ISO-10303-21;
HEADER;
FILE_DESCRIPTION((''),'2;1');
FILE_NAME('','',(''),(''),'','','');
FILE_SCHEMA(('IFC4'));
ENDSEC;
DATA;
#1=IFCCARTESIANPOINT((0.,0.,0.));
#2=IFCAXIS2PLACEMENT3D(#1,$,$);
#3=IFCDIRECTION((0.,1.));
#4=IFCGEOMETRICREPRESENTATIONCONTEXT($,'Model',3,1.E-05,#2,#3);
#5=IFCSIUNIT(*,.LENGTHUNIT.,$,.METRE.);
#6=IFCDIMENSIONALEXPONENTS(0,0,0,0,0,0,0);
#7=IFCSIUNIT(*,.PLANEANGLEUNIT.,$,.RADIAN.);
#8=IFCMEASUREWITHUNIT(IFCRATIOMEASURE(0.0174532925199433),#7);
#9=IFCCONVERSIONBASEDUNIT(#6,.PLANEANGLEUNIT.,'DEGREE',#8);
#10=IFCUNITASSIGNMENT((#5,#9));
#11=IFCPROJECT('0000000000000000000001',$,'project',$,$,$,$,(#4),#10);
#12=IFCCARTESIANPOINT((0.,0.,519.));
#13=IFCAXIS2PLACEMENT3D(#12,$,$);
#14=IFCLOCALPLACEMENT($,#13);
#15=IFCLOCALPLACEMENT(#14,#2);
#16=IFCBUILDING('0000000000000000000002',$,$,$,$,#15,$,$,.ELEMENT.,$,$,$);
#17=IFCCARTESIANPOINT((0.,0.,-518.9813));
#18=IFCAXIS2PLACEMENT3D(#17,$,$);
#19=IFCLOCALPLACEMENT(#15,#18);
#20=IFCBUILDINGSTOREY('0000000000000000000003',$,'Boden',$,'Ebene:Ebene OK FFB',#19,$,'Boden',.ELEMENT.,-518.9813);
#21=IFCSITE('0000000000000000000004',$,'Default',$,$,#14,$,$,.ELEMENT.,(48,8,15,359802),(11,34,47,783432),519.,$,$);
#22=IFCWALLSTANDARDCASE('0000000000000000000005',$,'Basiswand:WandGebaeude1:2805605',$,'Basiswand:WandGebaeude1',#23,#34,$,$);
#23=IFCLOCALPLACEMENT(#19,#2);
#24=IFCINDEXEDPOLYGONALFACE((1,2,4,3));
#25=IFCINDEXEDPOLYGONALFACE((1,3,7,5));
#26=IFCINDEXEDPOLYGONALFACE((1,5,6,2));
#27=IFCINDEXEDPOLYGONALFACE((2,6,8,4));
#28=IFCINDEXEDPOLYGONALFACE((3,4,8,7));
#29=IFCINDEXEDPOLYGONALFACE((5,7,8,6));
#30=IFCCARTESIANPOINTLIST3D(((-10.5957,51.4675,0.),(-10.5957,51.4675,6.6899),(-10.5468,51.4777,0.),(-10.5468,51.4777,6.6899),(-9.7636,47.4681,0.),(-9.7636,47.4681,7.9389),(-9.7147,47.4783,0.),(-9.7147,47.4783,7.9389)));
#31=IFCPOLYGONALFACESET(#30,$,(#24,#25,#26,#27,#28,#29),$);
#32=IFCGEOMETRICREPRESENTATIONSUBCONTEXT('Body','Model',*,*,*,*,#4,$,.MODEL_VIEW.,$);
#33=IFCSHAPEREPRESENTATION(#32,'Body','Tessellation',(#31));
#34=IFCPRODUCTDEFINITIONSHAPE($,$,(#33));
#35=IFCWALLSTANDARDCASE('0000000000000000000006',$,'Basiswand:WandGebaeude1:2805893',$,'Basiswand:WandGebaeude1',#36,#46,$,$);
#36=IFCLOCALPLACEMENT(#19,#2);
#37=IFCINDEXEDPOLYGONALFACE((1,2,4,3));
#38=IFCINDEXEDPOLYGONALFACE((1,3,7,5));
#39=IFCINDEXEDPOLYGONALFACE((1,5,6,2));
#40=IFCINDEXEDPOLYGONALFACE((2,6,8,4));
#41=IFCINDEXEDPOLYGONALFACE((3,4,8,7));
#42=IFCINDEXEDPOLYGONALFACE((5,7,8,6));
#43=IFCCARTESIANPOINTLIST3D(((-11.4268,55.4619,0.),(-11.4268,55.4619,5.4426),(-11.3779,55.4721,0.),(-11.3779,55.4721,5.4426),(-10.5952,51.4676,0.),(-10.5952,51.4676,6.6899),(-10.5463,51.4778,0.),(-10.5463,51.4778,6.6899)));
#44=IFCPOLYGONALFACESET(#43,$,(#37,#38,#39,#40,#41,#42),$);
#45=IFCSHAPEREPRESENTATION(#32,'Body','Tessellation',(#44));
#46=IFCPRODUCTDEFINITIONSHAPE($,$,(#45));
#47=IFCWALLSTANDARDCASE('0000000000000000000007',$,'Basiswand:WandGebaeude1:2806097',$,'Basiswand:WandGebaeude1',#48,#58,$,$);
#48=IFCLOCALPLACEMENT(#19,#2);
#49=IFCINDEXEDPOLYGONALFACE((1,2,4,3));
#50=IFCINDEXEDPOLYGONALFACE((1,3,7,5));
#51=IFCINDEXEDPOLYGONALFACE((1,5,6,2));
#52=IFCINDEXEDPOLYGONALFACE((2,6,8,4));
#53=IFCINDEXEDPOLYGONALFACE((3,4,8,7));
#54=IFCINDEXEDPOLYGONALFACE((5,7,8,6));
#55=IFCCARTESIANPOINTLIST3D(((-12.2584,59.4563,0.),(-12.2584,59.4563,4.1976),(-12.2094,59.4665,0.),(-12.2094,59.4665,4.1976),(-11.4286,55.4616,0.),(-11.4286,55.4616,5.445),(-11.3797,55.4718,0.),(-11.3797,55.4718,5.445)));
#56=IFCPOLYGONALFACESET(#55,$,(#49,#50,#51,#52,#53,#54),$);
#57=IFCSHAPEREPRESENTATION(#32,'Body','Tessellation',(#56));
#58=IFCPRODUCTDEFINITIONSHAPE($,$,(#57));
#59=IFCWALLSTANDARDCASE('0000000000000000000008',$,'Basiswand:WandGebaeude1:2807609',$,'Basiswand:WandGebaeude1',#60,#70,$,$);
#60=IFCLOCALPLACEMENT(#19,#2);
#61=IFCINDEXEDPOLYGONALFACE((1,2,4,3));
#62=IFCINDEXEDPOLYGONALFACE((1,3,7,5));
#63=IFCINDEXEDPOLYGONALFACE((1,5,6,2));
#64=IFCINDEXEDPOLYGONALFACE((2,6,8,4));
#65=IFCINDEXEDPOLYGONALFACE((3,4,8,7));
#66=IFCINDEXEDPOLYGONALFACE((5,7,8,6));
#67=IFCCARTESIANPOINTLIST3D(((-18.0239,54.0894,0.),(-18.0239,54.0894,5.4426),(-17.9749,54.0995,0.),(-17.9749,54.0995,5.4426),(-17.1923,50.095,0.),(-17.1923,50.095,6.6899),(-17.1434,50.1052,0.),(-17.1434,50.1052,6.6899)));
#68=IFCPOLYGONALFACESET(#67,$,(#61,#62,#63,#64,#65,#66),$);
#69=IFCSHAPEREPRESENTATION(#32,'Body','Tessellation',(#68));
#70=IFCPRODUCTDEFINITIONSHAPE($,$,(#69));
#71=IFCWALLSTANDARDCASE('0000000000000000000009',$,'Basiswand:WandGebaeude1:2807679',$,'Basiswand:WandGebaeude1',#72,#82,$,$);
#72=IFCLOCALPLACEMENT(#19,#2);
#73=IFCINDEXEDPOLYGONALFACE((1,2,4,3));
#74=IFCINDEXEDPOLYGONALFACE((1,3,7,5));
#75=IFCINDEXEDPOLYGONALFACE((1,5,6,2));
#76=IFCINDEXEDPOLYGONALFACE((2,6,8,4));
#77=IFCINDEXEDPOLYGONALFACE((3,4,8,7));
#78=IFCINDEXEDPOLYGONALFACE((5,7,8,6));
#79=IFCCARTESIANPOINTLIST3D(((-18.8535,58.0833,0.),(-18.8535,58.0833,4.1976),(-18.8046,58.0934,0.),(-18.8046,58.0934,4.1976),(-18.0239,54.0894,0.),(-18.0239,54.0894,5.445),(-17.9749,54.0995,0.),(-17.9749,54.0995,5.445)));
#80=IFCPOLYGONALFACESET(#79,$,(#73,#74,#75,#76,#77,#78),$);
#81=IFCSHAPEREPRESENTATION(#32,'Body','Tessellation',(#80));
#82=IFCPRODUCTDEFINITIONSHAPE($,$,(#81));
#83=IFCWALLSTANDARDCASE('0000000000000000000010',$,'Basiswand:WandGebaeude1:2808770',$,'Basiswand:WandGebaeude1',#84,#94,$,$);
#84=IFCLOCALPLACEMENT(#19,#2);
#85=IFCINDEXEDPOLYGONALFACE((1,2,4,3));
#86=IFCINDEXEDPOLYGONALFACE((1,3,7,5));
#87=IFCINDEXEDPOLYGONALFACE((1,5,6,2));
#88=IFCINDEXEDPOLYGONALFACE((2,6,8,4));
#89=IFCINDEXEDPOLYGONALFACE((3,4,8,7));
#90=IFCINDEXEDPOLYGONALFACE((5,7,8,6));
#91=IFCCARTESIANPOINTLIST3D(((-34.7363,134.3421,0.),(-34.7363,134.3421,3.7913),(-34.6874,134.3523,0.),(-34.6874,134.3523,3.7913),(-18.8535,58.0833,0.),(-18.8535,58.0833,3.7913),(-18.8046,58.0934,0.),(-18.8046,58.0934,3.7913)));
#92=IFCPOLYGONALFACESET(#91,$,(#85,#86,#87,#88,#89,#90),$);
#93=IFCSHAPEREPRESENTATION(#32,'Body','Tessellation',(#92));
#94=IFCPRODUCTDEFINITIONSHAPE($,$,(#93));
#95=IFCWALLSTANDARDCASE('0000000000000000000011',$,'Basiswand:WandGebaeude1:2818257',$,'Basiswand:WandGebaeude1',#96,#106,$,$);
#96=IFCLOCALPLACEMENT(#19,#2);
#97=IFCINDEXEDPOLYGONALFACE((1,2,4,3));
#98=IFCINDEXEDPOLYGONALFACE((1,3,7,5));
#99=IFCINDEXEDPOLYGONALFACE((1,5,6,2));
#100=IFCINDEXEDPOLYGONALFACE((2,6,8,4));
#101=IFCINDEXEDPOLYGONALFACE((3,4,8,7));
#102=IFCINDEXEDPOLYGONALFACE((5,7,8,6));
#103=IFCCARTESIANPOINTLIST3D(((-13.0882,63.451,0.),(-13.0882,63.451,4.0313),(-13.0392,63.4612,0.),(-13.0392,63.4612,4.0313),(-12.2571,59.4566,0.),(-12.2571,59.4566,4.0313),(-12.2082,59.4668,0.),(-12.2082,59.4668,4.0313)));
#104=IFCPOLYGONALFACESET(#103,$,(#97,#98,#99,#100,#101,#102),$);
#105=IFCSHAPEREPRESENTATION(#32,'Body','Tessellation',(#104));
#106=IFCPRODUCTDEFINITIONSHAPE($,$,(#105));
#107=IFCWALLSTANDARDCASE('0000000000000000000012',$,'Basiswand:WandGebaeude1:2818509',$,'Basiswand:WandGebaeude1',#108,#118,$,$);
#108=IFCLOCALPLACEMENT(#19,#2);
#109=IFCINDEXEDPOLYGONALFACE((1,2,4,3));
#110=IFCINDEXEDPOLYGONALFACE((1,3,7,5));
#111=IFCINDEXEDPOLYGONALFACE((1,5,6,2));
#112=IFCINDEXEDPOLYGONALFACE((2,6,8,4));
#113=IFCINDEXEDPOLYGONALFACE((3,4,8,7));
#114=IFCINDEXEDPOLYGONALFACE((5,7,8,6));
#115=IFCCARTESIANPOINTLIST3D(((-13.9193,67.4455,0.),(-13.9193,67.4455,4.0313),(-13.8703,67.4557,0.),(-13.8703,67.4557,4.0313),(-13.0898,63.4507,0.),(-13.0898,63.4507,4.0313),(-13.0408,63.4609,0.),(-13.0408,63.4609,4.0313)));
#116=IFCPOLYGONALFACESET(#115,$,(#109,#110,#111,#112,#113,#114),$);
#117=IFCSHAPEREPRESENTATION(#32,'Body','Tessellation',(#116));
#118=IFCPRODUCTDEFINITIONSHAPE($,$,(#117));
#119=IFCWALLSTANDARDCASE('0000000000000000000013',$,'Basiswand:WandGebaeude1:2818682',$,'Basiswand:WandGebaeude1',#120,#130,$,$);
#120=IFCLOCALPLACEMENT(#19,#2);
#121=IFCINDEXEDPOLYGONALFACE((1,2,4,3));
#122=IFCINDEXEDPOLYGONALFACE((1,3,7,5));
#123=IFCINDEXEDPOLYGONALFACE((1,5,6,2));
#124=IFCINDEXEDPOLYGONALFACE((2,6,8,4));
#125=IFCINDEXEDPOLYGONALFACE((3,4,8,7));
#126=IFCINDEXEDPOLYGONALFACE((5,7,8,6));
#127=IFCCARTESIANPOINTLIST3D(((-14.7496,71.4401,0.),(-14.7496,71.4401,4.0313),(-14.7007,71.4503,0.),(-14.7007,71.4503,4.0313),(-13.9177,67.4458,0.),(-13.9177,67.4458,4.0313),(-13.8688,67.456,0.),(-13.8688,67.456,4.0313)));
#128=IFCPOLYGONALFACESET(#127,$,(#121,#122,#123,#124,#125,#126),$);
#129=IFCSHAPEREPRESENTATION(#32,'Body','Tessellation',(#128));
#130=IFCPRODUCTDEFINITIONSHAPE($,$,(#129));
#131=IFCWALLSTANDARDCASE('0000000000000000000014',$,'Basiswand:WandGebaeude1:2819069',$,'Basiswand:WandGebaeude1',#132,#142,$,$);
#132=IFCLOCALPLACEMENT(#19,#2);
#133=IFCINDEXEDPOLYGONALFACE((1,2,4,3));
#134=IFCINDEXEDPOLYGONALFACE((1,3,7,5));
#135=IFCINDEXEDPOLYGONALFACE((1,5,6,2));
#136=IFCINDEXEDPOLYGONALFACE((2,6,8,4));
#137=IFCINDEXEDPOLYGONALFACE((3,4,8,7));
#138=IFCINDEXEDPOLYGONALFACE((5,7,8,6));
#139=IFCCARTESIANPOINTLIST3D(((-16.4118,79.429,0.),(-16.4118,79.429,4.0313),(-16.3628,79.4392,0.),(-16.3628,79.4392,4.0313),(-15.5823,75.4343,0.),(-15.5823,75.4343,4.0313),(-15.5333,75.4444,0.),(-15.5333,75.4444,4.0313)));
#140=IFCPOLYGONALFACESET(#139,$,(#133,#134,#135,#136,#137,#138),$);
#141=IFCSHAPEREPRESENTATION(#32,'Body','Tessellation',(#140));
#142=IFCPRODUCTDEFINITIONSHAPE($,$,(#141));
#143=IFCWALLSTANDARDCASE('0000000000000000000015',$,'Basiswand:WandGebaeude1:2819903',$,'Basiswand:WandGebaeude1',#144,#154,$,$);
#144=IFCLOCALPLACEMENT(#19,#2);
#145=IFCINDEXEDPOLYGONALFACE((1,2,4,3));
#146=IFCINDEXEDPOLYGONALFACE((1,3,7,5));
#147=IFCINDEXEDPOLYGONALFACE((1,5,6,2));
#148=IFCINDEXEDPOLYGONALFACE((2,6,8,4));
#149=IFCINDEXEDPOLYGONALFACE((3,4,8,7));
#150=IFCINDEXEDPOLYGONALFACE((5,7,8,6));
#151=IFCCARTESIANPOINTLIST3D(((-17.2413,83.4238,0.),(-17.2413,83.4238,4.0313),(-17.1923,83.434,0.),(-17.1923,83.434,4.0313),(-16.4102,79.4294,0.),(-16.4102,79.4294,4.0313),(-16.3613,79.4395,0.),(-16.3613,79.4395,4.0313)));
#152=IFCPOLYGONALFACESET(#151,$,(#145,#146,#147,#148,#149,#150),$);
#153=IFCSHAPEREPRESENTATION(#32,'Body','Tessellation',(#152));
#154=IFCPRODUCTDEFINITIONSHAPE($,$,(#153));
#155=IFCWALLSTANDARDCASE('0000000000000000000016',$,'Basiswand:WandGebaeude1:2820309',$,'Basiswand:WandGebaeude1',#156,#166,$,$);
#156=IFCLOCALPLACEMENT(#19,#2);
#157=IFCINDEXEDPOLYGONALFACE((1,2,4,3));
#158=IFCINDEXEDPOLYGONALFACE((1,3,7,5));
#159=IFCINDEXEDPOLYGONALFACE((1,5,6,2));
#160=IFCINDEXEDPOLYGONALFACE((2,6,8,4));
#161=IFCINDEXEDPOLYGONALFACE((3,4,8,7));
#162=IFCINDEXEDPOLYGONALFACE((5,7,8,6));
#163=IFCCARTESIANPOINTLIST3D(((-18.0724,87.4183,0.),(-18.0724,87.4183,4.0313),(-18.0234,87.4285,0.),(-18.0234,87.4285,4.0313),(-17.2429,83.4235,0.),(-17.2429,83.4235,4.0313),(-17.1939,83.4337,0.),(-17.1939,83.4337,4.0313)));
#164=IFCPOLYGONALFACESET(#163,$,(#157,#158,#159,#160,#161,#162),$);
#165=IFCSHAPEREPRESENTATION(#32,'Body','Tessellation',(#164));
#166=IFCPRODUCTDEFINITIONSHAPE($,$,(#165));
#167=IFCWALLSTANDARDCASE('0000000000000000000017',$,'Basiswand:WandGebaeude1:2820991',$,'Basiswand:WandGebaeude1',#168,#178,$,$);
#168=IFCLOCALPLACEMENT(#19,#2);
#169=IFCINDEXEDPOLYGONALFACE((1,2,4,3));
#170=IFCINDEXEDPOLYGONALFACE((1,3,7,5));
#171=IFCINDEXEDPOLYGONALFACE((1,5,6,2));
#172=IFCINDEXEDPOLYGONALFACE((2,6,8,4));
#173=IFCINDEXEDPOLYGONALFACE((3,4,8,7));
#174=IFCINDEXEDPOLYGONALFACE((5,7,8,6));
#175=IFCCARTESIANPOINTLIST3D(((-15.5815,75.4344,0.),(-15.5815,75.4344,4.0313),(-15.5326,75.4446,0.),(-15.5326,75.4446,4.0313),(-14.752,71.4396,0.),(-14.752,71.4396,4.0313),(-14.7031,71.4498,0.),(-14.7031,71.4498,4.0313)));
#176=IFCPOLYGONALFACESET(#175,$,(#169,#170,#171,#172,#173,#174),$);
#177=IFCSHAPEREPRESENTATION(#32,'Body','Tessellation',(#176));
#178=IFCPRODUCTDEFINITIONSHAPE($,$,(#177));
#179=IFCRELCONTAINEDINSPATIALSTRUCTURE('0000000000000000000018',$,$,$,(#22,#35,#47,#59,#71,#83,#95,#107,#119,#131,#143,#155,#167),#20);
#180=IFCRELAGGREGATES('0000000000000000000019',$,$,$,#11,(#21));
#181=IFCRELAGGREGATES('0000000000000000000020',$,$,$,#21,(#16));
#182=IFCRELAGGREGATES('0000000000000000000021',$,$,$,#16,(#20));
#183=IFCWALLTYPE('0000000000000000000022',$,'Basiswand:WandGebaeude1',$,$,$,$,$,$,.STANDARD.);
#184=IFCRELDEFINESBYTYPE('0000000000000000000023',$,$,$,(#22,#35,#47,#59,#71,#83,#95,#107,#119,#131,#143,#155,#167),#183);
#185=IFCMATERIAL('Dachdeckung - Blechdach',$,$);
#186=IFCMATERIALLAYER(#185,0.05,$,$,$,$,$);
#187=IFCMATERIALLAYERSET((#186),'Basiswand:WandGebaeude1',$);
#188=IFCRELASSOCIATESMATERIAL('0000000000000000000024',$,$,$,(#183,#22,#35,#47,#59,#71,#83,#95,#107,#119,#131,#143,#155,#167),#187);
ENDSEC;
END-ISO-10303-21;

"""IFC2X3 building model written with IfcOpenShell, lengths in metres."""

from ifc_helpers import new_model, entity, si_unit, converted_unit, direction, frame, frame_2d, origin, place, context, subcontext, project, spatial, polyline, rectangle, outline, extrude, clip, halfspace, material, layer, layer_set, layer_usage, type_object, element, save


model = new_model("IFC2X3")

# Units and contexts
model_context = context("Model", 3, precision=1e-05, world=origin(), true_north=direction((0.0, 1.0)))
body_context = subcontext(model_context, "Body", "Model", "MODEL_VIEW")
ifc_project = project(units=[si_unit("LENGTHUNIT", "METRE"), converted_unit("PLANEANGLEUNIT", "DEGREE", entity("IfcRatioMeasure", 0.0174532925199433), si_unit("PLANEANGLEUNIT", "RADIAN"), dimensions=[0, 0, 0, 0, 0, 0, 0])], contexts=[model_context])

# Site, building, storey
site_placement = place(None, frame((0.0, 0.0, 519.0)))
site = spatial("IfcSite", under=ifc_project, at=site_placement, Name="Default", CompositionType="ELEMENT", RefLatitude=(48, 8, 15, 359802), RefLongitude=(11, 34, 47, 783432), RefElevation=519.0)
building_placement = place(site_placement, origin())
building = spatial("IfcBuilding", under=site, at=building_placement, CompositionType="ELEMENT")
storey_placement = place(building_placement, frame((0.0, 0.0, -518.9813)))
storey = spatial("IfcBuildingStorey", under=building, at=storey_placement, Name="Boden", ObjectType="Ebene:Ebene OK FFB", LongName="Boden", CompositionType="ELEMENT", Elevation=-518.9813)

# Walls
ifc_material_1 = material(Name="Dachdeckung - Blechdach")
ifc_layer_1 = layer(ifc_material_1, 0.05)
ifc_layer_set_1 = layer_set([ifc_layer_1], Name="Basiswand:WandGebaeude1")
ifc_layer_usage_1 = layer_usage(ifc_layer_set_1, "AXIS2", "NEGATIVE", 0.025)
wall_type_1 = type_object("IfcWallType", Name="Basiswand:WandGebaeude1", PredefinedType="STANDARD", material=ifc_layer_set_1)
wall_1_placement = place(storey_placement, frame((-9.7392, 47.4732, 0.0), z_axis=(0.0, 0.0, 1.0), x_axis=(-0.203696, 0.979034, 0.0)))
element("IfcWallStandardCase", 1, at=wall_1_placement, inside=storey, type_object=wall_type_1, material=ifc_layer_usage_1, Name="Basiswand:WandGebaeude1:2805605", ObjectType="Basiswand:WandGebaeude1", context=body_context, shape_type="Clipping", body=[
    clip(extrude(rectangle(XDim=4.085, YDim=0.05, at=frame_2d((2.0425, 0.0), x_axis=(-1.0, 0.0))), origin(), (0.0, 0.0, 1.0), 7.9389), halfspace(frame((0.0, -0.025, 7.9389), z_axis=(0.292372, 0.0, 0.956305), x_axis=(0.0, 1.0, 0.0)), False)),
])
ifc_layer_usage_2 = layer_usage(ifc_layer_set_1, "AXIS2", "NEGATIVE", 0.025)
wall_2_placement = place(storey_placement, frame((-10.5708, 51.4727, 0.0), z_axis=(0.0, 0.0, 1.0), x_axis=(-0.20382, 0.979008, 0.0)))
element("IfcWallStandardCase", 2, at=wall_2_placement, inside=storey, type_object=wall_type_1, material=ifc_layer_usage_2, Name="Basiswand:WandGebaeude1:2805893", ObjectType="Basiswand:WandGebaeude1", context=body_context, shape_type="Clipping", body=[
    clip(extrude(rectangle(XDim=4.08, YDim=0.05, at=frame_2d((2.04, 0.0), x_axis=(-1.0, 0.0))), origin(), (0.0, 0.0, 1.0), 6.6899), halfspace(frame((0.0, -0.025, 6.6899), z_axis=(0.292372, 0.0, 0.956305), x_axis=(0.0, 1.0, 0.0)), False)),
])
ifc_layer_usage_3 = layer_usage(ifc_layer_set_1, "AXIS2", "NEGATIVE", 0.025)
wall_3_placement = place(storey_placement, frame((-11.4041, 55.4667, 0.0), z_axis=(0.0, 0.0, 1.0), x_axis=(-0.203381, 0.9791, 0.0)))
element("IfcWallStandardCase", 3, at=wall_3_placement, inside=storey, type_object=wall_type_1, material=ifc_layer_usage_3, Name="Basiswand:WandGebaeude1:2806097", ObjectType="Basiswand:WandGebaeude1", context=body_context, shape_type="Clipping", body=[
    clip(extrude(rectangle(XDim=4.08, YDim=0.05, at=frame_2d((2.04, 0.0), x_axis=(-1.0, 0.0))), origin(), (0.0, 0.0, 1.0), 5.445), halfspace(frame((0.0, -0.025, 5.445), z_axis=(0.292372, 0.0, 0.956305), x_axis=(0.0, 1.0, 0.0)), False)),
])
ifc_layer_usage_4 = layer_usage(ifc_layer_set_1, "AXIS2", "NEGATIVE", 0.025)
wall_4_placement = place(storey_placement, frame((-17.1678, 50.1001, 0.0), z_axis=(0.0, 0.0, 1.0), x_axis=(-0.20382, 0.979008, 0.0)))
element("IfcWallStandardCase", 4, at=wall_4_placement, inside=storey, type_object=wall_type_1, material=ifc_layer_usage_4, Name="Basiswand:WandGebaeude1:2807609", ObjectType="Basiswand:WandGebaeude1", context=body_context, shape_type="Clipping", body=[
    clip(extrude(rectangle(XDim=4.08, YDim=0.05, at=frame_2d((2.04, 0.0), x_axis=(-1.0, 0.0))), origin(), (0.0, 0.0, 1.0), 6.6899), halfspace(frame((0.0, -0.025, 6.6899), z_axis=(0.292372, 0.0, 0.956305), x_axis=(0.0, 1.0, 0.0)), False)),
])
ifc_layer_usage_5 = layer_usage(ifc_layer_set_1, "AXIS2", "NEGATIVE", 0.025)
wall_5_placement = place(storey_placement, frame((-17.9994, 54.0944, 0.0), z_axis=(0.0, 0.0, 1.0), x_axis=(-0.203381, 0.9791, 0.0)))
element("IfcWallStandardCase", 5, at=wall_5_placement, inside=storey, type_object=wall_type_1, material=ifc_layer_usage_5, Name="Basiswand:WandGebaeude1:2807679", ObjectType="Basiswand:WandGebaeude1", context=body_context, shape_type="Clipping", body=[
    clip(extrude(rectangle(XDim=4.0792, YDim=0.05, at=frame_2d((2.0396, 0.0), x_axis=(-1.0, 0.0))), origin(), (0.0, 0.0, 1.0), 5.445), halfspace(frame((0.0, -0.025, 5.445), z_axis=(0.292428, 0.0, 0.956288), x_axis=(0.0, 1.0, 0.0)), False)),
])
ifc_layer_usage_6 = layer_usage(ifc_layer_set_1, "AXIS2", "NEGATIVE", 0.025)
wall_6_placement = place(storey_placement, frame((-18.829, 58.0884, 0.0), z_axis=(0.0, 0.0, 1.0), x_axis=(-0.203899, 0.978992, 0.0)))
element("IfcWallStandardCase", 6, at=wall_6_placement, inside=storey, type_object=wall_type_1, material=ifc_layer_usage_6, Name="Basiswand:WandGebaeude1:2808770", ObjectType="Basiswand:WandGebaeude1", context=body_context, shape_type="SweptSolid", body=[
    extrude(outline(polyline([(77.8953, -0.025), (77.8953, 0.025), (0.0, 0.025), (0.0, -0.025), (77.8953, -0.025)])), origin(), (0.0, 0.0, 1.0), 3.7913),
])
ifc_layer_usage_7 = layer_usage(ifc_layer_set_1, "AXIS2", "NEGATIVE", 0.025)
wall_7_placement = place(storey_placement, frame((-12.2326, 59.4617, 0.0), z_axis=(0.0, 0.0, 1.0), x_axis=(-0.203696, 0.979034, 0.0)))
element("IfcWallStandardCase", 7, at=wall_7_placement, inside=storey, type_object=wall_type_1, material=ifc_layer_usage_7, Name="Basiswand:WandGebaeude1:2818257", ObjectType="Basiswand:WandGebaeude1", context=body_context, shape_type="SweptSolid", body=[
    extrude(rectangle(XDim=4.08, YDim=0.05, at=frame_2d((2.04, 0.0), x_axis=(-1.0, 0.0))), origin(), (0.0, 0.0, 1.0), 4.0313),
])
ifc_layer_usage_8 = layer_usage(ifc_layer_set_1, "AXIS2", "NEGATIVE", 0.025)
wall_8_placement = place(storey_placement, frame((-13.0653, 63.4558, 0.0), z_axis=(0.0, 0.0, 1.0), x_axis=(-0.203311, 0.979114, 0.0)))
element("IfcWallStandardCase", 8, at=wall_8_placement, inside=storey, type_object=wall_type_1, material=ifc_layer_usage_8, Name="Basiswand:WandGebaeude1:2818509", ObjectType="Basiswand:WandGebaeude1", context=body_context, shape_type="SweptSolid", body=[
    extrude(rectangle(XDim=4.08, YDim=0.05, at=frame_2d((2.04, 0.0), x_axis=(-1.0, 0.0))), origin(), (0.0, 0.0, 1.0), 4.0313),
])
ifc_layer_usage_9 = layer_usage(ifc_layer_set_1, "AXIS2", "NEGATIVE", 0.025)
wall_9_placement = place(storey_placement, frame((-13.8932, 67.4509, 0.0), z_axis=(0.0, 0.0, 1.0), x_axis=(-0.203899, 0.978992, 0.0)))
element("IfcWallStandardCase", 9, at=wall_9_placement, inside=storey, type_object=wall_type_1, material=ifc_layer_usage_9, Name="Basiswand:WandGebaeude1:2818682", ObjectType="Basiswand:WandGebaeude1", context=body_context, shape_type="SweptSolid", body=[
    extrude(rectangle(XDim=4.08, YDim=0.05, at=frame_2d((2.04, 0.0), x_axis=(-1.0, 0.0))), origin(), (0.0, 0.0, 1.0), 4.0313),
])
ifc_layer_usage_10 = layer_usage(ifc_layer_set_1, "AXIS2", "NEGATIVE", 0.025)
wall_10_placement = place(storey_placement, frame((-15.5578, 75.4393, 0.0), z_axis=(0.0, 0.0, 1.0), x_axis=(-0.203311, 0.979114, 0.0)))
element("IfcWallStandardCase", 10, at=wall_10_placement, inside=storey, type_object=wall_type_1, material=ifc_layer_usage_10, Name="Basiswand:WandGebaeude1:2819069", ObjectType="Basiswand:WandGebaeude1", context=body_context, shape_type="SweptSolid", body=[
    extrude(rectangle(XDim=4.08, YDim=0.05, at=frame_2d((2.04, 0.0), x_axis=(-1.0, 0.0))), origin(), (0.0, 0.0, 1.0), 4.0313),
])
ifc_layer_usage_11 = layer_usage(ifc_layer_set_1, "AXIS2", "NEGATIVE", 0.025)
wall_11_placement = place(storey_placement, frame((-16.3857, 79.4345, 0.0), z_axis=(0.0, 0.0, 1.0), x_axis=(-0.203696, 0.979034, 0.0)))
element("IfcWallStandardCase", 11, at=wall_11_placement, inside=storey, type_object=wall_type_1, material=ifc_layer_usage_11, Name="Basiswand:WandGebaeude1:2819903", ObjectType="Basiswand:WandGebaeude1", context=body_context, shape_type="SweptSolid", body=[
    extrude(rectangle(XDim=4.08, YDim=0.05, at=frame_2d((2.04, 0.0), x_axis=(-1.0, 0.0))), origin(), (0.0, 0.0, 1.0), 4.0313),
])
ifc_layer_usage_12 = layer_usage(ifc_layer_set_1, "AXIS2", "NEGATIVE", 0.025)
wall_12_placement = place(storey_placement, frame((-17.2184, 83.4286, 0.0), z_axis=(0.0, 0.0, 1.0), x_axis=(-0.203311, 0.979114, 0.0)))
element("IfcWallStandardCase", 12, at=wall_12_placement, inside=storey, type_object=wall_type_1, material=ifc_layer_usage_12, Name="Basiswand:WandGebaeude1:2820309", ObjectType="Basiswand:WandGebaeude1", context=body_context, shape_type="SweptSolid", body=[
    extrude(rectangle(XDim=4.08, YDim=0.05, at=frame_2d((2.04, 0.0), x_axis=(-1.0, 0.0))), origin(), (0.0, 0.0, 1.0), 4.0313),
])
ifc_layer_usage_13 = layer_usage(ifc_layer_set_1, "AXIS2", "NEGATIVE", 0.025)
wall_13_placement = place(storey_placement, frame((-14.7275, 71.4447, 0.0), z_axis=(0.0, 0.0, 1.0), x_axis=(-0.203311, 0.979114, 0.0)))
element("IfcWallStandardCase", 13, at=wall_13_placement, inside=storey, type_object=wall_type_1, material=ifc_layer_usage_13, Name="Basiswand:WandGebaeude1:2820991", ObjectType="Basiswand:WandGebaeude1", context=body_context, shape_type="SweptSolid", body=[
    extrude(rectangle(XDim=4.08, YDim=0.05, at=frame_2d((2.04, 0.0), x_axis=(-1.0, 0.0))), origin(), (0.0, 0.0, 1.0), 4.0313),
])

save(model, "model.ifc")
